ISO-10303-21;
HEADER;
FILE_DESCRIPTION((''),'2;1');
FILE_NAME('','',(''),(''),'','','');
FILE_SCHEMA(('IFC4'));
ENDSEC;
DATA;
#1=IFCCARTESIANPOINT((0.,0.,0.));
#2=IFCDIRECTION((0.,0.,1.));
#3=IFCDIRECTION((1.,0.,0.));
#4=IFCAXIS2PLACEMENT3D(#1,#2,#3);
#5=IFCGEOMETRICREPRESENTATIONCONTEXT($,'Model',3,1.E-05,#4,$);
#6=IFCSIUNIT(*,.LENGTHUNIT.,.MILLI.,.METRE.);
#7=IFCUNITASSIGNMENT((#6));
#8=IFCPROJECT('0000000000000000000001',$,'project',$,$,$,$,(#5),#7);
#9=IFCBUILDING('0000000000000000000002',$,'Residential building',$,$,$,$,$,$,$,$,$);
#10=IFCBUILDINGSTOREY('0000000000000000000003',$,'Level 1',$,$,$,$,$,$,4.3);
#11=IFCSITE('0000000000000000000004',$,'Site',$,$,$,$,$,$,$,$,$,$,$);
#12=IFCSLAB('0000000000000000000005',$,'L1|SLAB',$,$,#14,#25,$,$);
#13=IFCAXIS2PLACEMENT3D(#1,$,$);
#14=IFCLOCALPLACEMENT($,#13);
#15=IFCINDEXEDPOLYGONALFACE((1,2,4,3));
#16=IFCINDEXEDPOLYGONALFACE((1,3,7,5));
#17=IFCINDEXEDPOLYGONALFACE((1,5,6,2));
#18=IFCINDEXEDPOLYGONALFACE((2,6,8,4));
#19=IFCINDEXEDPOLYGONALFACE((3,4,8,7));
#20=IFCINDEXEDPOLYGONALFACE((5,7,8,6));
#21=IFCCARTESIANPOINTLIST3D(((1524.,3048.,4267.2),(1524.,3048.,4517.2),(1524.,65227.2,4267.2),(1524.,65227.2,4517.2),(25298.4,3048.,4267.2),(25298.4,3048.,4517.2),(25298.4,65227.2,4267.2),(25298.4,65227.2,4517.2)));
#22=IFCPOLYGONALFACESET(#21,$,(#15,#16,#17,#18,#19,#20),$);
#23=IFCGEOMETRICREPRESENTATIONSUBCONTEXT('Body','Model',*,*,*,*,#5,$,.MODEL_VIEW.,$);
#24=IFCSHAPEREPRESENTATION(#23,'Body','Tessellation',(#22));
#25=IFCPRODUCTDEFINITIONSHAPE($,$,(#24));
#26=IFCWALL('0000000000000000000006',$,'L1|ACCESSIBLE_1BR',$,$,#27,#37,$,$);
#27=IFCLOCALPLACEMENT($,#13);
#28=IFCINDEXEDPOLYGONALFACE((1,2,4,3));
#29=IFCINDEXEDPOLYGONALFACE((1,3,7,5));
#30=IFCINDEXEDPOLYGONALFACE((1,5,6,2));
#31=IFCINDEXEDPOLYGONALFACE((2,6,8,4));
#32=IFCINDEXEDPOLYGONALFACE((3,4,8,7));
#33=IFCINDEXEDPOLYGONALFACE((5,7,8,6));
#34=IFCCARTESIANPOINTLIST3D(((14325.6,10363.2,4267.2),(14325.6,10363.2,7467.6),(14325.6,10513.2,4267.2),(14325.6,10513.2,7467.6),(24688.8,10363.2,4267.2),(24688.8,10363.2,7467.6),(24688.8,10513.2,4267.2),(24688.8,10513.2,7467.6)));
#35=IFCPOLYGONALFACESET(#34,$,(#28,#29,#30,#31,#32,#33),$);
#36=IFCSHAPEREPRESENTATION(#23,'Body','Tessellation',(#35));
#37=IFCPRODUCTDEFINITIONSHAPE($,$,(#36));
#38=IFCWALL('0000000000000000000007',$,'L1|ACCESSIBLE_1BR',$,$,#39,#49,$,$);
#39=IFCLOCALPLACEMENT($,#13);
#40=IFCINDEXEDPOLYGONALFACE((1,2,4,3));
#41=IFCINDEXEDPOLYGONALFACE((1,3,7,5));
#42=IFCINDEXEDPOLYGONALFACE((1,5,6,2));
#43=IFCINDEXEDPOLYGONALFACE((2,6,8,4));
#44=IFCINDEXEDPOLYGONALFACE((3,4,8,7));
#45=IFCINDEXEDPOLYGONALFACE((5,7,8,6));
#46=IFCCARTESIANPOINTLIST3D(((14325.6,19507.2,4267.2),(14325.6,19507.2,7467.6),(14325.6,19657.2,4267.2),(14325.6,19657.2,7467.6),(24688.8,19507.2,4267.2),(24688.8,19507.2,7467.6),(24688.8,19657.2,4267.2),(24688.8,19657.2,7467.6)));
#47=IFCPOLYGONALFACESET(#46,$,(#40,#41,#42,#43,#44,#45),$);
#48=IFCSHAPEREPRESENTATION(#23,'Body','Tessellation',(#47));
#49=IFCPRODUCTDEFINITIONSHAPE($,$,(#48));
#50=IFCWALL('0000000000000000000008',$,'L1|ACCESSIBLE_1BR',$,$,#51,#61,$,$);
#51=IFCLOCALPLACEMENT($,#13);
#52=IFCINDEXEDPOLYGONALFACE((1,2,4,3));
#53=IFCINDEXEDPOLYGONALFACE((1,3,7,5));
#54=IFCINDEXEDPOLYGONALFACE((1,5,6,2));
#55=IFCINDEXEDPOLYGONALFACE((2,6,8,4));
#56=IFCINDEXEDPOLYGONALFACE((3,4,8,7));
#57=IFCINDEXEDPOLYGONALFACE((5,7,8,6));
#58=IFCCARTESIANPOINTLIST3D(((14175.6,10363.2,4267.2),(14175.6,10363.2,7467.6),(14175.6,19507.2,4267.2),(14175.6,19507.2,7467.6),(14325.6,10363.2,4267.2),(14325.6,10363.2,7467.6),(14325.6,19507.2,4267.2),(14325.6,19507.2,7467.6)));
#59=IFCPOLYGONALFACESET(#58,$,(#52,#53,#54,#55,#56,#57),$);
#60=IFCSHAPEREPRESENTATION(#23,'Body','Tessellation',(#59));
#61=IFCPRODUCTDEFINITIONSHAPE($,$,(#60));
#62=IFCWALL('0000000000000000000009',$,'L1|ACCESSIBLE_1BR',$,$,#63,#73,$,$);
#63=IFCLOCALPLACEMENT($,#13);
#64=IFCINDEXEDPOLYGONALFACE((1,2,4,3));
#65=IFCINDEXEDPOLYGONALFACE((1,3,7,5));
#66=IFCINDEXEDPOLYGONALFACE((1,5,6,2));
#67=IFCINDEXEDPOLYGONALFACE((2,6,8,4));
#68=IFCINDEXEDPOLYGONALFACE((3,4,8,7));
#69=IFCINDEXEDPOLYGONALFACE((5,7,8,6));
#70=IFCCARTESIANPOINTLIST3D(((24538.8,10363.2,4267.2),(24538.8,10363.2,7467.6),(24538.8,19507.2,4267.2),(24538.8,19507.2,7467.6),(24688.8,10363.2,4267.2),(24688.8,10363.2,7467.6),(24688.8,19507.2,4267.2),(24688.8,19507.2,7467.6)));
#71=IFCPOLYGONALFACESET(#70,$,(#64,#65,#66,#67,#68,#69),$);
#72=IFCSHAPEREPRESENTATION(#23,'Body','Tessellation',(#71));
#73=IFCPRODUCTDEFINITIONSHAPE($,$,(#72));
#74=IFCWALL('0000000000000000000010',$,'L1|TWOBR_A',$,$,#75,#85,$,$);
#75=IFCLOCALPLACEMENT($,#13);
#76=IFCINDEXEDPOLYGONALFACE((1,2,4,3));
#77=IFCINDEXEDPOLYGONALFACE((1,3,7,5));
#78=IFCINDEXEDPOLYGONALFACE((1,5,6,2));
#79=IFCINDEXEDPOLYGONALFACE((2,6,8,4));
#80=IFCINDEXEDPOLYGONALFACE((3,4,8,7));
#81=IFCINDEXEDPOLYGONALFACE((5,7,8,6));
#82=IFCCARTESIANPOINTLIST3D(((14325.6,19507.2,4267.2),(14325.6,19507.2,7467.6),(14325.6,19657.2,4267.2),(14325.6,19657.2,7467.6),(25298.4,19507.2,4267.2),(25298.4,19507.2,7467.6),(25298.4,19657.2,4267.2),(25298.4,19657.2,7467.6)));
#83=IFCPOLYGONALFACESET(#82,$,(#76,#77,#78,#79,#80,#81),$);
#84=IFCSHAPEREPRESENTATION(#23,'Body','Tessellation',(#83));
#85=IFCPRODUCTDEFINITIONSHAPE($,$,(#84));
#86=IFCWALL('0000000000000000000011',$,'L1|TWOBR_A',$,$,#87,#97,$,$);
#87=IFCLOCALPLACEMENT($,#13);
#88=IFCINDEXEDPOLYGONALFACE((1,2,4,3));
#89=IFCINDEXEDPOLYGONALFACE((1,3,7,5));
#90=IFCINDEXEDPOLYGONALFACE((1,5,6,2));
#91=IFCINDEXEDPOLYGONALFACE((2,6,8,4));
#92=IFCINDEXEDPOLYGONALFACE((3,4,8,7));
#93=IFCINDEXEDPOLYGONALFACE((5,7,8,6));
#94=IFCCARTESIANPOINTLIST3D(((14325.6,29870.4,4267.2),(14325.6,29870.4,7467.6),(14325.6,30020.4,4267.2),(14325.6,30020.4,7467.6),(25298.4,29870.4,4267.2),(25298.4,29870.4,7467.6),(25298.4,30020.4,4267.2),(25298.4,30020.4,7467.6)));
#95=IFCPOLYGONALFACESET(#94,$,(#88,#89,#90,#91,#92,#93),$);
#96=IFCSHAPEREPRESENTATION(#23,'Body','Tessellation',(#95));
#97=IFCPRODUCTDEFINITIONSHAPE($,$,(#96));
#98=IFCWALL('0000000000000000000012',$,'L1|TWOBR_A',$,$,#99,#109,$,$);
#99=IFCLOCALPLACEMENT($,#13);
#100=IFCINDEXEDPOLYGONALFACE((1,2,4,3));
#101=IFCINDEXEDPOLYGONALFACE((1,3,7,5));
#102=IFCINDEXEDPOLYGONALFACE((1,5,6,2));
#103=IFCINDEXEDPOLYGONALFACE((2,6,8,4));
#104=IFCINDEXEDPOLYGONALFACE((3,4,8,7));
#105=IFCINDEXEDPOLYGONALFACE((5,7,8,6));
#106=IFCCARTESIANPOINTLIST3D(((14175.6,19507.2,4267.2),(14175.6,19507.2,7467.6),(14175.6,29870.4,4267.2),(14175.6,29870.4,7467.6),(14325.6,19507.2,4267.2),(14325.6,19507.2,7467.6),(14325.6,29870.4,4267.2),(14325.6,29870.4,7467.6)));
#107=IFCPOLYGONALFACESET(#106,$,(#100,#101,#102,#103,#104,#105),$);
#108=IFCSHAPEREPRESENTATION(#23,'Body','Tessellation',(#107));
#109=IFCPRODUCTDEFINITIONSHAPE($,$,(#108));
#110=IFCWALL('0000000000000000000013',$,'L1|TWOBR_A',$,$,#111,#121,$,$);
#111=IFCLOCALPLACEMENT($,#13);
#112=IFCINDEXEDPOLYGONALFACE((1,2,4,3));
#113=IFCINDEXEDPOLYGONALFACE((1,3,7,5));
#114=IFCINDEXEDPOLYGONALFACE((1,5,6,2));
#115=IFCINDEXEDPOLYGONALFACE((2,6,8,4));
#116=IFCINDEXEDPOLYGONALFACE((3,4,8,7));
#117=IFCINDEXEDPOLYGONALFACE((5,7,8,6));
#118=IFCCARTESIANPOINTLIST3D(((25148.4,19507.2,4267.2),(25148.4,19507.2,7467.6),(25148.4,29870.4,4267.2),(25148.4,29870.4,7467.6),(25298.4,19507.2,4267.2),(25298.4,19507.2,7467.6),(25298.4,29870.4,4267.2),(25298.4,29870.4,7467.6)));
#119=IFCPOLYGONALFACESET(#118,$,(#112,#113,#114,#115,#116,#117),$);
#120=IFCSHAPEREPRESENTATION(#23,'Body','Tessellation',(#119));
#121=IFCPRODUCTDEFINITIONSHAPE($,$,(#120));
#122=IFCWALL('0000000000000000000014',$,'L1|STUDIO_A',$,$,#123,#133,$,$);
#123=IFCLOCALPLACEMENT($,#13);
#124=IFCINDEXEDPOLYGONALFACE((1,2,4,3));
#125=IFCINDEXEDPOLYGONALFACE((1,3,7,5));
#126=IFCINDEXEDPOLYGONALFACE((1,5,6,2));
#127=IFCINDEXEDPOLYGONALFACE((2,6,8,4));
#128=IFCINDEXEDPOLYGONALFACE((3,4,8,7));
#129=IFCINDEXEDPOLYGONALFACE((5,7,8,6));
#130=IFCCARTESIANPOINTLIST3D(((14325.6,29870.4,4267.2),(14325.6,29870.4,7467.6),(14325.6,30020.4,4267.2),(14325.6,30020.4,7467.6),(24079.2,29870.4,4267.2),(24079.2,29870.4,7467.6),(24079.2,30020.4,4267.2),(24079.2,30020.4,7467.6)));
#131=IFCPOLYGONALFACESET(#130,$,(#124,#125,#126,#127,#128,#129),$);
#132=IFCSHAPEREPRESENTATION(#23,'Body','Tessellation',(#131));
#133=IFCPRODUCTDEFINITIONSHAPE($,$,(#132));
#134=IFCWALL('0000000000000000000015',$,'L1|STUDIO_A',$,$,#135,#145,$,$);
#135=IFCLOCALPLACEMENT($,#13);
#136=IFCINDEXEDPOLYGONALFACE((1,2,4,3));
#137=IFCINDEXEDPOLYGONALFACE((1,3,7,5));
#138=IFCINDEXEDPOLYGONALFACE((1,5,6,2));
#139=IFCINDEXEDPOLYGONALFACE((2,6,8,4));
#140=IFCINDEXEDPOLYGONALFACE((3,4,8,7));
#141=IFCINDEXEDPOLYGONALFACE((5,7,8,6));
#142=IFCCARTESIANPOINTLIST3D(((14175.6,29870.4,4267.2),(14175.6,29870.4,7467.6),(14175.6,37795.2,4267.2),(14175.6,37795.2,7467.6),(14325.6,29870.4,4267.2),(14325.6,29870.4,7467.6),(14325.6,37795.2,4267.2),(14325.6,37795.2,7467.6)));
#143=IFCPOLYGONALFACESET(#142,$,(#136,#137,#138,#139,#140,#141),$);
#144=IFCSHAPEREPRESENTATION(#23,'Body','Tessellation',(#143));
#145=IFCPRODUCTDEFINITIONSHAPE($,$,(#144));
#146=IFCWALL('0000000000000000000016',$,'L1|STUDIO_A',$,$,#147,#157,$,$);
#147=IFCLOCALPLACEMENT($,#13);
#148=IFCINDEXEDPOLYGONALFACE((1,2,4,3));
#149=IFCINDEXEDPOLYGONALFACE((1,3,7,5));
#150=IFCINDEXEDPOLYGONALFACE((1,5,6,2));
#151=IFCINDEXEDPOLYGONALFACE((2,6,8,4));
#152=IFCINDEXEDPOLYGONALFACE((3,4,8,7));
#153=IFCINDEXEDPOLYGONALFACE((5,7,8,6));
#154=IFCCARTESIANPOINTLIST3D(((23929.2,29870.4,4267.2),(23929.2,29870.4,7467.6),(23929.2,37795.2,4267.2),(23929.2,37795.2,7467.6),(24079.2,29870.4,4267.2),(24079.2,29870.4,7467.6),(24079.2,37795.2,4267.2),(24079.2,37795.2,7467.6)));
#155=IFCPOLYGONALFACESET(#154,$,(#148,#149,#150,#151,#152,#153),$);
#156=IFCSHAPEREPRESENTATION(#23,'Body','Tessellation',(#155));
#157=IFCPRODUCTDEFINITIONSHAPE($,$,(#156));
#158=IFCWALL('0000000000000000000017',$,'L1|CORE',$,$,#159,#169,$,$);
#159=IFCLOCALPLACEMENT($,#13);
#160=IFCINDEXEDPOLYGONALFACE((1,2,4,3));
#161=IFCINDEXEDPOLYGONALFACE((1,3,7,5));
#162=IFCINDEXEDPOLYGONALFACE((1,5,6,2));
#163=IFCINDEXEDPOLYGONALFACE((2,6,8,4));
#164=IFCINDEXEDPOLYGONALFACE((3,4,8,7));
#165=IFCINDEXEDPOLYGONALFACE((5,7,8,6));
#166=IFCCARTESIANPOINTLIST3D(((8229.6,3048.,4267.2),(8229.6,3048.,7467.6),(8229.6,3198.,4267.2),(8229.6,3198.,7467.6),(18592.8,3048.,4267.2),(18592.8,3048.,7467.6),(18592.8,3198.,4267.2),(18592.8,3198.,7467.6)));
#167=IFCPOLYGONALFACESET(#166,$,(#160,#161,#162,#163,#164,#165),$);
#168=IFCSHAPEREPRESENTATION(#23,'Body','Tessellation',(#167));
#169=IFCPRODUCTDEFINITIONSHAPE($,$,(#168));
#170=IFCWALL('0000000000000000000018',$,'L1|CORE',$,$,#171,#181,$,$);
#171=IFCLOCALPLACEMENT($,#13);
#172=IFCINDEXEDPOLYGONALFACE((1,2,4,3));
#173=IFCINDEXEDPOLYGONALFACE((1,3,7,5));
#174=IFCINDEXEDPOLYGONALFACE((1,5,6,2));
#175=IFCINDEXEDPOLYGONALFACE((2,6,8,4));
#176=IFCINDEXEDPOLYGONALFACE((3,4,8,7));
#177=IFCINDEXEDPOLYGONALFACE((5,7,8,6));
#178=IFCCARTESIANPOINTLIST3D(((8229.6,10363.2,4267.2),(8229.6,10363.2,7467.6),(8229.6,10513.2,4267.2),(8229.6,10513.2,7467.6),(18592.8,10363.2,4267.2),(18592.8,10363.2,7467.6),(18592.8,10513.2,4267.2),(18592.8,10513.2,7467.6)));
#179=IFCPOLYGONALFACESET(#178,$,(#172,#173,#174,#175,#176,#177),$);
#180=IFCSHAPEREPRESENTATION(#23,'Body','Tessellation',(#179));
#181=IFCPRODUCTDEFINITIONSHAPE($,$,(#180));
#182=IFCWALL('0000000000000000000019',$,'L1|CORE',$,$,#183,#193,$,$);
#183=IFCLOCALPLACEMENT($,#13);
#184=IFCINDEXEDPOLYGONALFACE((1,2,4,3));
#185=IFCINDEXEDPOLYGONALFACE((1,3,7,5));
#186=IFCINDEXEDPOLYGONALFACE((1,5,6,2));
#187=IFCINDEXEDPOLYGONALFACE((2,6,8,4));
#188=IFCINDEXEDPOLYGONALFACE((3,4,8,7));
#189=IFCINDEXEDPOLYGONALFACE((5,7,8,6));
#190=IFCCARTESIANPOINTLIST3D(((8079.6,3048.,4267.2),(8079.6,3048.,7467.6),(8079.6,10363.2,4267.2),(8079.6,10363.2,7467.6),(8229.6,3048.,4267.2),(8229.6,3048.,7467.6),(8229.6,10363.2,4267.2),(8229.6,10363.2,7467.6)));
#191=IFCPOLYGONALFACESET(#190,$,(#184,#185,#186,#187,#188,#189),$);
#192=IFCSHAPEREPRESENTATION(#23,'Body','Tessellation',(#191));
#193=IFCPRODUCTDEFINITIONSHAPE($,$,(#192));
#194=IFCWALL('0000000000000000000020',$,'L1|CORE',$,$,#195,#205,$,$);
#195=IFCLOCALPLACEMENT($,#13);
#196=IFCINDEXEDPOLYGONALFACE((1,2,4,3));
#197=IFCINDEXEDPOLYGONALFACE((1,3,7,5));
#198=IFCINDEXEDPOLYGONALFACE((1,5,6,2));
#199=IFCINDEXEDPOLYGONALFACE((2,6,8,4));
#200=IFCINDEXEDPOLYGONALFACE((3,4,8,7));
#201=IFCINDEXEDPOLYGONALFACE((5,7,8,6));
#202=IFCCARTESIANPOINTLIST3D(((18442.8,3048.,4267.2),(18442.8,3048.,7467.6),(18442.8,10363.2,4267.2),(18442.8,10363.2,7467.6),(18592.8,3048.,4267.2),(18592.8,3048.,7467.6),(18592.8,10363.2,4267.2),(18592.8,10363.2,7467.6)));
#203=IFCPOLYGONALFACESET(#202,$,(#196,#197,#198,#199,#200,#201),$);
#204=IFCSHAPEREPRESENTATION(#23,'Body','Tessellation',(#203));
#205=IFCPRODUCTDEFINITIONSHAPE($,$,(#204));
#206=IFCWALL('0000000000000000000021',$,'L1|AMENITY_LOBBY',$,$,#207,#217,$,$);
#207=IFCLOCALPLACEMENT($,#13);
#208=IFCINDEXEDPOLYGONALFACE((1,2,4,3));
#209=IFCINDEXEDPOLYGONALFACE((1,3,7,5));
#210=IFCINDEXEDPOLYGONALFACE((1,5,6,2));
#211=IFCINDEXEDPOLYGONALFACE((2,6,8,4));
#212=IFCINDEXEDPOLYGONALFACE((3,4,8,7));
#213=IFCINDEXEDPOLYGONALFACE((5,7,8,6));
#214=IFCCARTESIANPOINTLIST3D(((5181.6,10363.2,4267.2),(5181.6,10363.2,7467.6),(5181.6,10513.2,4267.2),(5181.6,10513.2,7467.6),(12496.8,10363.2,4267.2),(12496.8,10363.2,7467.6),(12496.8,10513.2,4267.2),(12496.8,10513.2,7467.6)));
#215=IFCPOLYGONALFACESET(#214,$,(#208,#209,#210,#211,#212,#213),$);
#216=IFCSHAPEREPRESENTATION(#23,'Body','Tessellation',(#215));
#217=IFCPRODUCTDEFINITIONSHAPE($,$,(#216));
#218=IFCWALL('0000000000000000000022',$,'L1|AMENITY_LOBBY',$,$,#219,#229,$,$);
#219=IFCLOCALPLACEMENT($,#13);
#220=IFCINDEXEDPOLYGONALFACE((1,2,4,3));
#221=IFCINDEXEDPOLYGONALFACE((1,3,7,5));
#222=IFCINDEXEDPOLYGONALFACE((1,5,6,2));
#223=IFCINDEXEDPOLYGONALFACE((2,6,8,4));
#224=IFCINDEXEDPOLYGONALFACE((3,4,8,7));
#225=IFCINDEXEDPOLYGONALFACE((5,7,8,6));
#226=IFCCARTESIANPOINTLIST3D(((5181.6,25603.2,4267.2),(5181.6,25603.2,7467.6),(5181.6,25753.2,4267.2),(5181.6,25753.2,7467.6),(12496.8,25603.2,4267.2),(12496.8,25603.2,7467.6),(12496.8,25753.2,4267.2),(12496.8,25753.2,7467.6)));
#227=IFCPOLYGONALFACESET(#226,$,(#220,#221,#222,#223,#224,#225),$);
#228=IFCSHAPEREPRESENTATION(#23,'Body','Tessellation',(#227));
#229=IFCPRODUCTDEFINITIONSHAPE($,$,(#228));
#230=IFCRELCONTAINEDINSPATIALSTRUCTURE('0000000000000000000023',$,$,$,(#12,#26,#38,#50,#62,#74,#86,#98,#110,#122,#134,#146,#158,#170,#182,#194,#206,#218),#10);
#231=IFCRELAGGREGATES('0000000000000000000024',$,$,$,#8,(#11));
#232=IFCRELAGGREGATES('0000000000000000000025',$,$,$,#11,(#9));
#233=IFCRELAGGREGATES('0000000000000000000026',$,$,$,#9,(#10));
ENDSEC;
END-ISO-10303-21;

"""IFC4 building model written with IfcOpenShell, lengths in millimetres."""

from ifc_helpers import new_model, si_unit, frame, origin_with_axes, place, context, subcontext, project, spatial, indexed_curve, outline, extrude, element, save


model = new_model("IFC4")

# Units and contexts
model_context = context("Model", 3, precision=1e-05, world=origin_with_axes())
body_context = subcontext(model_context, "Body", "Model", "MODEL_VIEW")
ifc_project = project(units=[si_unit("LENGTHUNIT", "METRE", prefix="MILLI")], contexts=[model_context])

# Site, building, storey
site = spatial("IfcSite", under=ifc_project, Name="Site")
building = spatial("IfcBuilding", under=site, Name="Residential building")
storey = spatial("IfcBuildingStorey", under=building, Name="Level 1", Elevation=4.3)

# Slab
slab_placement = place(None, frame((1524.0, 3048.0, 4267.2), z_axis=(0.0, 0.0, 1.0), x_axis=(1.0, 0.0, 0.0)))
element("IfcSlab", 1, at=slab_placement, inside=storey, Name="L1|SLAB", context=body_context, shape_type="SweptSolid", body=[
    extrude(outline(indexed_curve([(0.0, 0.0), (23774.4, 0.0), (23774.4, 62179.2), (0.0, 62179.2), (0.0, 0.0)])), None, (0.0, 0.0, 1.0), 250.0),
])

# Walls
for number, where, z_axis, x_axis, name in (
    (2, (14325.6, 10363.2, 4267.2), (0.0, 0.0, 1.0), (1.0, 0.0, 0.0), "L1|ACCESSIBLE_1BR"),
    (3, (14325.6, 19507.2, 4267.2), (0.0, 0.0, 1.0), (1.0, 0.0, 0.0), "L1|ACCESSIBLE_1BR"),
):
    element("IfcWall", number, at=place(None, frame(where, z_axis=z_axis, x_axis=x_axis)), inside=storey, Name=name, context=body_context, shape_type="SweptSolid", body=[
        extrude(outline(indexed_curve([(0.0, 0.0), (0.0, 150.0), (10363.2, 150.0), (10363.2, 0.0), (0.0, 0.0)], self_intersect=False)), origin_with_axes(), (0.0, 0.0, 1.0), 3200.4),
    ])
for number, where, z_axis, x_axis, name in (
    (4, (14325.6, 10363.2, 4267.2), (0.0, 0.0, 1.0), (0.0, 1.0, 0.0), "L1|ACCESSIBLE_1BR"),
    (5, (24688.8, 10363.2, 4267.2), (0.0, 0.0, 1.0), (0.0, 1.0, 0.0), "L1|ACCESSIBLE_1BR"),
):
    element("IfcWall", number, at=place(None, frame(where, z_axis=z_axis, x_axis=x_axis)), inside=storey, Name=name, context=body_context, shape_type="SweptSolid", body=[
        extrude(outline(indexed_curve([(0.0, 0.0), (0.0, 150.0), (9144.0, 150.0), (9144.0, 0.0), (0.0, 0.0)], self_intersect=False)), origin_with_axes(), (0.0, 0.0, 1.0), 3200.4),
    ])
for number, where, z_axis, x_axis, name in (
    (6, (14325.6, 19507.2, 4267.2), (0.0, 0.0, 1.0), (1.0, 0.0, 0.0), "L1|TWOBR_A"),
    (7, (14325.6, 29870.4, 4267.2), (0.0, 0.0, 1.0), (1.0, 0.0, 0.0), "L1|TWOBR_A"),
):
    element("IfcWall", number, at=place(None, frame(where, z_axis=z_axis, x_axis=x_axis)), inside=storey, Name=name, context=body_context, shape_type="SweptSolid", body=[
        extrude(outline(indexed_curve([(0.0, 0.0), (0.0, 150.0), (10972.8, 150.0), (10972.8, 0.0), (0.0, 0.0)], self_intersect=False)), origin_with_axes(), (0.0, 0.0, 1.0), 3200.4),
    ])
for number, where, z_axis, x_axis, name in (
    (8, (14325.6, 19507.2, 4267.2), (0.0, 0.0, 1.0), (0.0, 1.0, 0.0), "L1|TWOBR_A"),
    (9, (25298.4, 19507.2, 4267.2), (0.0, 0.0, 1.0), (0.0, 1.0, 0.0), "L1|TWOBR_A"),
):
    element("IfcWall", number, at=place(None, frame(where, z_axis=z_axis, x_axis=x_axis)), inside=storey, Name=name, context=body_context, shape_type="SweptSolid", body=[
        extrude(outline(indexed_curve([(0.0, 0.0), (0.0, 150.0), (10363.2, 150.0), (10363.2, 0.0), (0.0, 0.0)], self_intersect=False)), origin_with_axes(), (0.0, 0.0, 1.0), 3200.4),
    ])
wall_1_placement = place(None, frame((14325.6, 29870.4, 4267.2), z_axis=(0.0, 0.0, 1.0), x_axis=(1.0, 0.0, 0.0)))
element("IfcWall", 10, at=wall_1_placement, inside=storey, Name="L1|STUDIO_A", context=body_context, shape_type="SweptSolid", body=[
    extrude(outline(indexed_curve([(0.0, 0.0), (0.0, 150.0), (9753.6, 150.0), (9753.6, 0.0), (0.0, 0.0)], self_intersect=False)), origin_with_axes(), (0.0, 0.0, 1.0), 3200.4),
])
for number, where, z_axis, x_axis, name in (
    (11, (14325.6, 29870.4, 4267.2), (0.0, 0.0, 1.0), (0.0, 1.0, 0.0), "L1|STUDIO_A"),
    (12, (24079.2, 29870.4, 4267.2), (0.0, 0.0, 1.0), (0.0, 1.0, 0.0), "L1|STUDIO_A"),
):
    element("IfcWall", number, at=place(None, frame(where, z_axis=z_axis, x_axis=x_axis)), inside=storey, Name=name, context=body_context, shape_type="SweptSolid", body=[
        extrude(outline(indexed_curve([(0.0, 0.0), (0.0, 150.0), (7924.8, 150.0), (7924.8, 0.0), (0.0, 0.0)], self_intersect=False)), origin_with_axes(), (0.0, 0.0, 1.0), 3200.4),
    ])
for number, where, z_axis, x_axis, name in (
    (13, (8229.6, 3048.0, 4267.2), (0.0, 0.0, 1.0), (1.0, 0.0, 0.0), "L1|CORE"),
    (14, (8229.6, 10363.2, 4267.2), (0.0, 0.0, 1.0), (1.0, 0.0, 0.0), "L1|CORE"),
):
    element("IfcWall", number, at=place(None, frame(where, z_axis=z_axis, x_axis=x_axis)), inside=storey, Name=name, context=body_context, shape_type="SweptSolid", body=[
        extrude(outline(indexed_curve([(0.0, 0.0), (0.0, 150.0), (10363.2, 150.0), (10363.2, 0.0), (0.0, 0.0)], self_intersect=False)), origin_with_axes(), (0.0, 0.0, 1.0), 3200.4),
    ])
for number, where, z_axis, x_axis, name in (
    (15, (8229.6, 3048.0, 4267.2), (0.0, 0.0, 1.0), (0.0, 1.0, 0.0), "L1|CORE"),
    (16, (18592.8, 3048.0, 4267.2), (0.0, 0.0, 1.0), (0.0, 1.0, 0.0), "L1|CORE"),
    (17, (5181.6, 10363.2, 4267.2), (0.0, 0.0, 1.0), (1.0, 0.0, 0.0), "L1|AMENITY_LOBBY"),
    (18, (5181.6, 25603.2, 4267.2), (0.0, 0.0, 1.0), (1.0, 0.0, 0.0), "L1|AMENITY_LOBBY"),
):
    element("IfcWall", number, at=place(None, frame(where, z_axis=z_axis, x_axis=x_axis)), inside=storey, Name=name, context=body_context, shape_type="SweptSolid", body=[
        extrude(outline(indexed_curve([(0.0, 0.0), (0.0, 150.0), (7315.2, 150.0), (7315.2, 0.0), (0.0, 0.0)], self_intersect=False)), origin_with_axes(), (0.0, 0.0, 1.0), 3200.4),
    ])

save(model, "model.ifc")
